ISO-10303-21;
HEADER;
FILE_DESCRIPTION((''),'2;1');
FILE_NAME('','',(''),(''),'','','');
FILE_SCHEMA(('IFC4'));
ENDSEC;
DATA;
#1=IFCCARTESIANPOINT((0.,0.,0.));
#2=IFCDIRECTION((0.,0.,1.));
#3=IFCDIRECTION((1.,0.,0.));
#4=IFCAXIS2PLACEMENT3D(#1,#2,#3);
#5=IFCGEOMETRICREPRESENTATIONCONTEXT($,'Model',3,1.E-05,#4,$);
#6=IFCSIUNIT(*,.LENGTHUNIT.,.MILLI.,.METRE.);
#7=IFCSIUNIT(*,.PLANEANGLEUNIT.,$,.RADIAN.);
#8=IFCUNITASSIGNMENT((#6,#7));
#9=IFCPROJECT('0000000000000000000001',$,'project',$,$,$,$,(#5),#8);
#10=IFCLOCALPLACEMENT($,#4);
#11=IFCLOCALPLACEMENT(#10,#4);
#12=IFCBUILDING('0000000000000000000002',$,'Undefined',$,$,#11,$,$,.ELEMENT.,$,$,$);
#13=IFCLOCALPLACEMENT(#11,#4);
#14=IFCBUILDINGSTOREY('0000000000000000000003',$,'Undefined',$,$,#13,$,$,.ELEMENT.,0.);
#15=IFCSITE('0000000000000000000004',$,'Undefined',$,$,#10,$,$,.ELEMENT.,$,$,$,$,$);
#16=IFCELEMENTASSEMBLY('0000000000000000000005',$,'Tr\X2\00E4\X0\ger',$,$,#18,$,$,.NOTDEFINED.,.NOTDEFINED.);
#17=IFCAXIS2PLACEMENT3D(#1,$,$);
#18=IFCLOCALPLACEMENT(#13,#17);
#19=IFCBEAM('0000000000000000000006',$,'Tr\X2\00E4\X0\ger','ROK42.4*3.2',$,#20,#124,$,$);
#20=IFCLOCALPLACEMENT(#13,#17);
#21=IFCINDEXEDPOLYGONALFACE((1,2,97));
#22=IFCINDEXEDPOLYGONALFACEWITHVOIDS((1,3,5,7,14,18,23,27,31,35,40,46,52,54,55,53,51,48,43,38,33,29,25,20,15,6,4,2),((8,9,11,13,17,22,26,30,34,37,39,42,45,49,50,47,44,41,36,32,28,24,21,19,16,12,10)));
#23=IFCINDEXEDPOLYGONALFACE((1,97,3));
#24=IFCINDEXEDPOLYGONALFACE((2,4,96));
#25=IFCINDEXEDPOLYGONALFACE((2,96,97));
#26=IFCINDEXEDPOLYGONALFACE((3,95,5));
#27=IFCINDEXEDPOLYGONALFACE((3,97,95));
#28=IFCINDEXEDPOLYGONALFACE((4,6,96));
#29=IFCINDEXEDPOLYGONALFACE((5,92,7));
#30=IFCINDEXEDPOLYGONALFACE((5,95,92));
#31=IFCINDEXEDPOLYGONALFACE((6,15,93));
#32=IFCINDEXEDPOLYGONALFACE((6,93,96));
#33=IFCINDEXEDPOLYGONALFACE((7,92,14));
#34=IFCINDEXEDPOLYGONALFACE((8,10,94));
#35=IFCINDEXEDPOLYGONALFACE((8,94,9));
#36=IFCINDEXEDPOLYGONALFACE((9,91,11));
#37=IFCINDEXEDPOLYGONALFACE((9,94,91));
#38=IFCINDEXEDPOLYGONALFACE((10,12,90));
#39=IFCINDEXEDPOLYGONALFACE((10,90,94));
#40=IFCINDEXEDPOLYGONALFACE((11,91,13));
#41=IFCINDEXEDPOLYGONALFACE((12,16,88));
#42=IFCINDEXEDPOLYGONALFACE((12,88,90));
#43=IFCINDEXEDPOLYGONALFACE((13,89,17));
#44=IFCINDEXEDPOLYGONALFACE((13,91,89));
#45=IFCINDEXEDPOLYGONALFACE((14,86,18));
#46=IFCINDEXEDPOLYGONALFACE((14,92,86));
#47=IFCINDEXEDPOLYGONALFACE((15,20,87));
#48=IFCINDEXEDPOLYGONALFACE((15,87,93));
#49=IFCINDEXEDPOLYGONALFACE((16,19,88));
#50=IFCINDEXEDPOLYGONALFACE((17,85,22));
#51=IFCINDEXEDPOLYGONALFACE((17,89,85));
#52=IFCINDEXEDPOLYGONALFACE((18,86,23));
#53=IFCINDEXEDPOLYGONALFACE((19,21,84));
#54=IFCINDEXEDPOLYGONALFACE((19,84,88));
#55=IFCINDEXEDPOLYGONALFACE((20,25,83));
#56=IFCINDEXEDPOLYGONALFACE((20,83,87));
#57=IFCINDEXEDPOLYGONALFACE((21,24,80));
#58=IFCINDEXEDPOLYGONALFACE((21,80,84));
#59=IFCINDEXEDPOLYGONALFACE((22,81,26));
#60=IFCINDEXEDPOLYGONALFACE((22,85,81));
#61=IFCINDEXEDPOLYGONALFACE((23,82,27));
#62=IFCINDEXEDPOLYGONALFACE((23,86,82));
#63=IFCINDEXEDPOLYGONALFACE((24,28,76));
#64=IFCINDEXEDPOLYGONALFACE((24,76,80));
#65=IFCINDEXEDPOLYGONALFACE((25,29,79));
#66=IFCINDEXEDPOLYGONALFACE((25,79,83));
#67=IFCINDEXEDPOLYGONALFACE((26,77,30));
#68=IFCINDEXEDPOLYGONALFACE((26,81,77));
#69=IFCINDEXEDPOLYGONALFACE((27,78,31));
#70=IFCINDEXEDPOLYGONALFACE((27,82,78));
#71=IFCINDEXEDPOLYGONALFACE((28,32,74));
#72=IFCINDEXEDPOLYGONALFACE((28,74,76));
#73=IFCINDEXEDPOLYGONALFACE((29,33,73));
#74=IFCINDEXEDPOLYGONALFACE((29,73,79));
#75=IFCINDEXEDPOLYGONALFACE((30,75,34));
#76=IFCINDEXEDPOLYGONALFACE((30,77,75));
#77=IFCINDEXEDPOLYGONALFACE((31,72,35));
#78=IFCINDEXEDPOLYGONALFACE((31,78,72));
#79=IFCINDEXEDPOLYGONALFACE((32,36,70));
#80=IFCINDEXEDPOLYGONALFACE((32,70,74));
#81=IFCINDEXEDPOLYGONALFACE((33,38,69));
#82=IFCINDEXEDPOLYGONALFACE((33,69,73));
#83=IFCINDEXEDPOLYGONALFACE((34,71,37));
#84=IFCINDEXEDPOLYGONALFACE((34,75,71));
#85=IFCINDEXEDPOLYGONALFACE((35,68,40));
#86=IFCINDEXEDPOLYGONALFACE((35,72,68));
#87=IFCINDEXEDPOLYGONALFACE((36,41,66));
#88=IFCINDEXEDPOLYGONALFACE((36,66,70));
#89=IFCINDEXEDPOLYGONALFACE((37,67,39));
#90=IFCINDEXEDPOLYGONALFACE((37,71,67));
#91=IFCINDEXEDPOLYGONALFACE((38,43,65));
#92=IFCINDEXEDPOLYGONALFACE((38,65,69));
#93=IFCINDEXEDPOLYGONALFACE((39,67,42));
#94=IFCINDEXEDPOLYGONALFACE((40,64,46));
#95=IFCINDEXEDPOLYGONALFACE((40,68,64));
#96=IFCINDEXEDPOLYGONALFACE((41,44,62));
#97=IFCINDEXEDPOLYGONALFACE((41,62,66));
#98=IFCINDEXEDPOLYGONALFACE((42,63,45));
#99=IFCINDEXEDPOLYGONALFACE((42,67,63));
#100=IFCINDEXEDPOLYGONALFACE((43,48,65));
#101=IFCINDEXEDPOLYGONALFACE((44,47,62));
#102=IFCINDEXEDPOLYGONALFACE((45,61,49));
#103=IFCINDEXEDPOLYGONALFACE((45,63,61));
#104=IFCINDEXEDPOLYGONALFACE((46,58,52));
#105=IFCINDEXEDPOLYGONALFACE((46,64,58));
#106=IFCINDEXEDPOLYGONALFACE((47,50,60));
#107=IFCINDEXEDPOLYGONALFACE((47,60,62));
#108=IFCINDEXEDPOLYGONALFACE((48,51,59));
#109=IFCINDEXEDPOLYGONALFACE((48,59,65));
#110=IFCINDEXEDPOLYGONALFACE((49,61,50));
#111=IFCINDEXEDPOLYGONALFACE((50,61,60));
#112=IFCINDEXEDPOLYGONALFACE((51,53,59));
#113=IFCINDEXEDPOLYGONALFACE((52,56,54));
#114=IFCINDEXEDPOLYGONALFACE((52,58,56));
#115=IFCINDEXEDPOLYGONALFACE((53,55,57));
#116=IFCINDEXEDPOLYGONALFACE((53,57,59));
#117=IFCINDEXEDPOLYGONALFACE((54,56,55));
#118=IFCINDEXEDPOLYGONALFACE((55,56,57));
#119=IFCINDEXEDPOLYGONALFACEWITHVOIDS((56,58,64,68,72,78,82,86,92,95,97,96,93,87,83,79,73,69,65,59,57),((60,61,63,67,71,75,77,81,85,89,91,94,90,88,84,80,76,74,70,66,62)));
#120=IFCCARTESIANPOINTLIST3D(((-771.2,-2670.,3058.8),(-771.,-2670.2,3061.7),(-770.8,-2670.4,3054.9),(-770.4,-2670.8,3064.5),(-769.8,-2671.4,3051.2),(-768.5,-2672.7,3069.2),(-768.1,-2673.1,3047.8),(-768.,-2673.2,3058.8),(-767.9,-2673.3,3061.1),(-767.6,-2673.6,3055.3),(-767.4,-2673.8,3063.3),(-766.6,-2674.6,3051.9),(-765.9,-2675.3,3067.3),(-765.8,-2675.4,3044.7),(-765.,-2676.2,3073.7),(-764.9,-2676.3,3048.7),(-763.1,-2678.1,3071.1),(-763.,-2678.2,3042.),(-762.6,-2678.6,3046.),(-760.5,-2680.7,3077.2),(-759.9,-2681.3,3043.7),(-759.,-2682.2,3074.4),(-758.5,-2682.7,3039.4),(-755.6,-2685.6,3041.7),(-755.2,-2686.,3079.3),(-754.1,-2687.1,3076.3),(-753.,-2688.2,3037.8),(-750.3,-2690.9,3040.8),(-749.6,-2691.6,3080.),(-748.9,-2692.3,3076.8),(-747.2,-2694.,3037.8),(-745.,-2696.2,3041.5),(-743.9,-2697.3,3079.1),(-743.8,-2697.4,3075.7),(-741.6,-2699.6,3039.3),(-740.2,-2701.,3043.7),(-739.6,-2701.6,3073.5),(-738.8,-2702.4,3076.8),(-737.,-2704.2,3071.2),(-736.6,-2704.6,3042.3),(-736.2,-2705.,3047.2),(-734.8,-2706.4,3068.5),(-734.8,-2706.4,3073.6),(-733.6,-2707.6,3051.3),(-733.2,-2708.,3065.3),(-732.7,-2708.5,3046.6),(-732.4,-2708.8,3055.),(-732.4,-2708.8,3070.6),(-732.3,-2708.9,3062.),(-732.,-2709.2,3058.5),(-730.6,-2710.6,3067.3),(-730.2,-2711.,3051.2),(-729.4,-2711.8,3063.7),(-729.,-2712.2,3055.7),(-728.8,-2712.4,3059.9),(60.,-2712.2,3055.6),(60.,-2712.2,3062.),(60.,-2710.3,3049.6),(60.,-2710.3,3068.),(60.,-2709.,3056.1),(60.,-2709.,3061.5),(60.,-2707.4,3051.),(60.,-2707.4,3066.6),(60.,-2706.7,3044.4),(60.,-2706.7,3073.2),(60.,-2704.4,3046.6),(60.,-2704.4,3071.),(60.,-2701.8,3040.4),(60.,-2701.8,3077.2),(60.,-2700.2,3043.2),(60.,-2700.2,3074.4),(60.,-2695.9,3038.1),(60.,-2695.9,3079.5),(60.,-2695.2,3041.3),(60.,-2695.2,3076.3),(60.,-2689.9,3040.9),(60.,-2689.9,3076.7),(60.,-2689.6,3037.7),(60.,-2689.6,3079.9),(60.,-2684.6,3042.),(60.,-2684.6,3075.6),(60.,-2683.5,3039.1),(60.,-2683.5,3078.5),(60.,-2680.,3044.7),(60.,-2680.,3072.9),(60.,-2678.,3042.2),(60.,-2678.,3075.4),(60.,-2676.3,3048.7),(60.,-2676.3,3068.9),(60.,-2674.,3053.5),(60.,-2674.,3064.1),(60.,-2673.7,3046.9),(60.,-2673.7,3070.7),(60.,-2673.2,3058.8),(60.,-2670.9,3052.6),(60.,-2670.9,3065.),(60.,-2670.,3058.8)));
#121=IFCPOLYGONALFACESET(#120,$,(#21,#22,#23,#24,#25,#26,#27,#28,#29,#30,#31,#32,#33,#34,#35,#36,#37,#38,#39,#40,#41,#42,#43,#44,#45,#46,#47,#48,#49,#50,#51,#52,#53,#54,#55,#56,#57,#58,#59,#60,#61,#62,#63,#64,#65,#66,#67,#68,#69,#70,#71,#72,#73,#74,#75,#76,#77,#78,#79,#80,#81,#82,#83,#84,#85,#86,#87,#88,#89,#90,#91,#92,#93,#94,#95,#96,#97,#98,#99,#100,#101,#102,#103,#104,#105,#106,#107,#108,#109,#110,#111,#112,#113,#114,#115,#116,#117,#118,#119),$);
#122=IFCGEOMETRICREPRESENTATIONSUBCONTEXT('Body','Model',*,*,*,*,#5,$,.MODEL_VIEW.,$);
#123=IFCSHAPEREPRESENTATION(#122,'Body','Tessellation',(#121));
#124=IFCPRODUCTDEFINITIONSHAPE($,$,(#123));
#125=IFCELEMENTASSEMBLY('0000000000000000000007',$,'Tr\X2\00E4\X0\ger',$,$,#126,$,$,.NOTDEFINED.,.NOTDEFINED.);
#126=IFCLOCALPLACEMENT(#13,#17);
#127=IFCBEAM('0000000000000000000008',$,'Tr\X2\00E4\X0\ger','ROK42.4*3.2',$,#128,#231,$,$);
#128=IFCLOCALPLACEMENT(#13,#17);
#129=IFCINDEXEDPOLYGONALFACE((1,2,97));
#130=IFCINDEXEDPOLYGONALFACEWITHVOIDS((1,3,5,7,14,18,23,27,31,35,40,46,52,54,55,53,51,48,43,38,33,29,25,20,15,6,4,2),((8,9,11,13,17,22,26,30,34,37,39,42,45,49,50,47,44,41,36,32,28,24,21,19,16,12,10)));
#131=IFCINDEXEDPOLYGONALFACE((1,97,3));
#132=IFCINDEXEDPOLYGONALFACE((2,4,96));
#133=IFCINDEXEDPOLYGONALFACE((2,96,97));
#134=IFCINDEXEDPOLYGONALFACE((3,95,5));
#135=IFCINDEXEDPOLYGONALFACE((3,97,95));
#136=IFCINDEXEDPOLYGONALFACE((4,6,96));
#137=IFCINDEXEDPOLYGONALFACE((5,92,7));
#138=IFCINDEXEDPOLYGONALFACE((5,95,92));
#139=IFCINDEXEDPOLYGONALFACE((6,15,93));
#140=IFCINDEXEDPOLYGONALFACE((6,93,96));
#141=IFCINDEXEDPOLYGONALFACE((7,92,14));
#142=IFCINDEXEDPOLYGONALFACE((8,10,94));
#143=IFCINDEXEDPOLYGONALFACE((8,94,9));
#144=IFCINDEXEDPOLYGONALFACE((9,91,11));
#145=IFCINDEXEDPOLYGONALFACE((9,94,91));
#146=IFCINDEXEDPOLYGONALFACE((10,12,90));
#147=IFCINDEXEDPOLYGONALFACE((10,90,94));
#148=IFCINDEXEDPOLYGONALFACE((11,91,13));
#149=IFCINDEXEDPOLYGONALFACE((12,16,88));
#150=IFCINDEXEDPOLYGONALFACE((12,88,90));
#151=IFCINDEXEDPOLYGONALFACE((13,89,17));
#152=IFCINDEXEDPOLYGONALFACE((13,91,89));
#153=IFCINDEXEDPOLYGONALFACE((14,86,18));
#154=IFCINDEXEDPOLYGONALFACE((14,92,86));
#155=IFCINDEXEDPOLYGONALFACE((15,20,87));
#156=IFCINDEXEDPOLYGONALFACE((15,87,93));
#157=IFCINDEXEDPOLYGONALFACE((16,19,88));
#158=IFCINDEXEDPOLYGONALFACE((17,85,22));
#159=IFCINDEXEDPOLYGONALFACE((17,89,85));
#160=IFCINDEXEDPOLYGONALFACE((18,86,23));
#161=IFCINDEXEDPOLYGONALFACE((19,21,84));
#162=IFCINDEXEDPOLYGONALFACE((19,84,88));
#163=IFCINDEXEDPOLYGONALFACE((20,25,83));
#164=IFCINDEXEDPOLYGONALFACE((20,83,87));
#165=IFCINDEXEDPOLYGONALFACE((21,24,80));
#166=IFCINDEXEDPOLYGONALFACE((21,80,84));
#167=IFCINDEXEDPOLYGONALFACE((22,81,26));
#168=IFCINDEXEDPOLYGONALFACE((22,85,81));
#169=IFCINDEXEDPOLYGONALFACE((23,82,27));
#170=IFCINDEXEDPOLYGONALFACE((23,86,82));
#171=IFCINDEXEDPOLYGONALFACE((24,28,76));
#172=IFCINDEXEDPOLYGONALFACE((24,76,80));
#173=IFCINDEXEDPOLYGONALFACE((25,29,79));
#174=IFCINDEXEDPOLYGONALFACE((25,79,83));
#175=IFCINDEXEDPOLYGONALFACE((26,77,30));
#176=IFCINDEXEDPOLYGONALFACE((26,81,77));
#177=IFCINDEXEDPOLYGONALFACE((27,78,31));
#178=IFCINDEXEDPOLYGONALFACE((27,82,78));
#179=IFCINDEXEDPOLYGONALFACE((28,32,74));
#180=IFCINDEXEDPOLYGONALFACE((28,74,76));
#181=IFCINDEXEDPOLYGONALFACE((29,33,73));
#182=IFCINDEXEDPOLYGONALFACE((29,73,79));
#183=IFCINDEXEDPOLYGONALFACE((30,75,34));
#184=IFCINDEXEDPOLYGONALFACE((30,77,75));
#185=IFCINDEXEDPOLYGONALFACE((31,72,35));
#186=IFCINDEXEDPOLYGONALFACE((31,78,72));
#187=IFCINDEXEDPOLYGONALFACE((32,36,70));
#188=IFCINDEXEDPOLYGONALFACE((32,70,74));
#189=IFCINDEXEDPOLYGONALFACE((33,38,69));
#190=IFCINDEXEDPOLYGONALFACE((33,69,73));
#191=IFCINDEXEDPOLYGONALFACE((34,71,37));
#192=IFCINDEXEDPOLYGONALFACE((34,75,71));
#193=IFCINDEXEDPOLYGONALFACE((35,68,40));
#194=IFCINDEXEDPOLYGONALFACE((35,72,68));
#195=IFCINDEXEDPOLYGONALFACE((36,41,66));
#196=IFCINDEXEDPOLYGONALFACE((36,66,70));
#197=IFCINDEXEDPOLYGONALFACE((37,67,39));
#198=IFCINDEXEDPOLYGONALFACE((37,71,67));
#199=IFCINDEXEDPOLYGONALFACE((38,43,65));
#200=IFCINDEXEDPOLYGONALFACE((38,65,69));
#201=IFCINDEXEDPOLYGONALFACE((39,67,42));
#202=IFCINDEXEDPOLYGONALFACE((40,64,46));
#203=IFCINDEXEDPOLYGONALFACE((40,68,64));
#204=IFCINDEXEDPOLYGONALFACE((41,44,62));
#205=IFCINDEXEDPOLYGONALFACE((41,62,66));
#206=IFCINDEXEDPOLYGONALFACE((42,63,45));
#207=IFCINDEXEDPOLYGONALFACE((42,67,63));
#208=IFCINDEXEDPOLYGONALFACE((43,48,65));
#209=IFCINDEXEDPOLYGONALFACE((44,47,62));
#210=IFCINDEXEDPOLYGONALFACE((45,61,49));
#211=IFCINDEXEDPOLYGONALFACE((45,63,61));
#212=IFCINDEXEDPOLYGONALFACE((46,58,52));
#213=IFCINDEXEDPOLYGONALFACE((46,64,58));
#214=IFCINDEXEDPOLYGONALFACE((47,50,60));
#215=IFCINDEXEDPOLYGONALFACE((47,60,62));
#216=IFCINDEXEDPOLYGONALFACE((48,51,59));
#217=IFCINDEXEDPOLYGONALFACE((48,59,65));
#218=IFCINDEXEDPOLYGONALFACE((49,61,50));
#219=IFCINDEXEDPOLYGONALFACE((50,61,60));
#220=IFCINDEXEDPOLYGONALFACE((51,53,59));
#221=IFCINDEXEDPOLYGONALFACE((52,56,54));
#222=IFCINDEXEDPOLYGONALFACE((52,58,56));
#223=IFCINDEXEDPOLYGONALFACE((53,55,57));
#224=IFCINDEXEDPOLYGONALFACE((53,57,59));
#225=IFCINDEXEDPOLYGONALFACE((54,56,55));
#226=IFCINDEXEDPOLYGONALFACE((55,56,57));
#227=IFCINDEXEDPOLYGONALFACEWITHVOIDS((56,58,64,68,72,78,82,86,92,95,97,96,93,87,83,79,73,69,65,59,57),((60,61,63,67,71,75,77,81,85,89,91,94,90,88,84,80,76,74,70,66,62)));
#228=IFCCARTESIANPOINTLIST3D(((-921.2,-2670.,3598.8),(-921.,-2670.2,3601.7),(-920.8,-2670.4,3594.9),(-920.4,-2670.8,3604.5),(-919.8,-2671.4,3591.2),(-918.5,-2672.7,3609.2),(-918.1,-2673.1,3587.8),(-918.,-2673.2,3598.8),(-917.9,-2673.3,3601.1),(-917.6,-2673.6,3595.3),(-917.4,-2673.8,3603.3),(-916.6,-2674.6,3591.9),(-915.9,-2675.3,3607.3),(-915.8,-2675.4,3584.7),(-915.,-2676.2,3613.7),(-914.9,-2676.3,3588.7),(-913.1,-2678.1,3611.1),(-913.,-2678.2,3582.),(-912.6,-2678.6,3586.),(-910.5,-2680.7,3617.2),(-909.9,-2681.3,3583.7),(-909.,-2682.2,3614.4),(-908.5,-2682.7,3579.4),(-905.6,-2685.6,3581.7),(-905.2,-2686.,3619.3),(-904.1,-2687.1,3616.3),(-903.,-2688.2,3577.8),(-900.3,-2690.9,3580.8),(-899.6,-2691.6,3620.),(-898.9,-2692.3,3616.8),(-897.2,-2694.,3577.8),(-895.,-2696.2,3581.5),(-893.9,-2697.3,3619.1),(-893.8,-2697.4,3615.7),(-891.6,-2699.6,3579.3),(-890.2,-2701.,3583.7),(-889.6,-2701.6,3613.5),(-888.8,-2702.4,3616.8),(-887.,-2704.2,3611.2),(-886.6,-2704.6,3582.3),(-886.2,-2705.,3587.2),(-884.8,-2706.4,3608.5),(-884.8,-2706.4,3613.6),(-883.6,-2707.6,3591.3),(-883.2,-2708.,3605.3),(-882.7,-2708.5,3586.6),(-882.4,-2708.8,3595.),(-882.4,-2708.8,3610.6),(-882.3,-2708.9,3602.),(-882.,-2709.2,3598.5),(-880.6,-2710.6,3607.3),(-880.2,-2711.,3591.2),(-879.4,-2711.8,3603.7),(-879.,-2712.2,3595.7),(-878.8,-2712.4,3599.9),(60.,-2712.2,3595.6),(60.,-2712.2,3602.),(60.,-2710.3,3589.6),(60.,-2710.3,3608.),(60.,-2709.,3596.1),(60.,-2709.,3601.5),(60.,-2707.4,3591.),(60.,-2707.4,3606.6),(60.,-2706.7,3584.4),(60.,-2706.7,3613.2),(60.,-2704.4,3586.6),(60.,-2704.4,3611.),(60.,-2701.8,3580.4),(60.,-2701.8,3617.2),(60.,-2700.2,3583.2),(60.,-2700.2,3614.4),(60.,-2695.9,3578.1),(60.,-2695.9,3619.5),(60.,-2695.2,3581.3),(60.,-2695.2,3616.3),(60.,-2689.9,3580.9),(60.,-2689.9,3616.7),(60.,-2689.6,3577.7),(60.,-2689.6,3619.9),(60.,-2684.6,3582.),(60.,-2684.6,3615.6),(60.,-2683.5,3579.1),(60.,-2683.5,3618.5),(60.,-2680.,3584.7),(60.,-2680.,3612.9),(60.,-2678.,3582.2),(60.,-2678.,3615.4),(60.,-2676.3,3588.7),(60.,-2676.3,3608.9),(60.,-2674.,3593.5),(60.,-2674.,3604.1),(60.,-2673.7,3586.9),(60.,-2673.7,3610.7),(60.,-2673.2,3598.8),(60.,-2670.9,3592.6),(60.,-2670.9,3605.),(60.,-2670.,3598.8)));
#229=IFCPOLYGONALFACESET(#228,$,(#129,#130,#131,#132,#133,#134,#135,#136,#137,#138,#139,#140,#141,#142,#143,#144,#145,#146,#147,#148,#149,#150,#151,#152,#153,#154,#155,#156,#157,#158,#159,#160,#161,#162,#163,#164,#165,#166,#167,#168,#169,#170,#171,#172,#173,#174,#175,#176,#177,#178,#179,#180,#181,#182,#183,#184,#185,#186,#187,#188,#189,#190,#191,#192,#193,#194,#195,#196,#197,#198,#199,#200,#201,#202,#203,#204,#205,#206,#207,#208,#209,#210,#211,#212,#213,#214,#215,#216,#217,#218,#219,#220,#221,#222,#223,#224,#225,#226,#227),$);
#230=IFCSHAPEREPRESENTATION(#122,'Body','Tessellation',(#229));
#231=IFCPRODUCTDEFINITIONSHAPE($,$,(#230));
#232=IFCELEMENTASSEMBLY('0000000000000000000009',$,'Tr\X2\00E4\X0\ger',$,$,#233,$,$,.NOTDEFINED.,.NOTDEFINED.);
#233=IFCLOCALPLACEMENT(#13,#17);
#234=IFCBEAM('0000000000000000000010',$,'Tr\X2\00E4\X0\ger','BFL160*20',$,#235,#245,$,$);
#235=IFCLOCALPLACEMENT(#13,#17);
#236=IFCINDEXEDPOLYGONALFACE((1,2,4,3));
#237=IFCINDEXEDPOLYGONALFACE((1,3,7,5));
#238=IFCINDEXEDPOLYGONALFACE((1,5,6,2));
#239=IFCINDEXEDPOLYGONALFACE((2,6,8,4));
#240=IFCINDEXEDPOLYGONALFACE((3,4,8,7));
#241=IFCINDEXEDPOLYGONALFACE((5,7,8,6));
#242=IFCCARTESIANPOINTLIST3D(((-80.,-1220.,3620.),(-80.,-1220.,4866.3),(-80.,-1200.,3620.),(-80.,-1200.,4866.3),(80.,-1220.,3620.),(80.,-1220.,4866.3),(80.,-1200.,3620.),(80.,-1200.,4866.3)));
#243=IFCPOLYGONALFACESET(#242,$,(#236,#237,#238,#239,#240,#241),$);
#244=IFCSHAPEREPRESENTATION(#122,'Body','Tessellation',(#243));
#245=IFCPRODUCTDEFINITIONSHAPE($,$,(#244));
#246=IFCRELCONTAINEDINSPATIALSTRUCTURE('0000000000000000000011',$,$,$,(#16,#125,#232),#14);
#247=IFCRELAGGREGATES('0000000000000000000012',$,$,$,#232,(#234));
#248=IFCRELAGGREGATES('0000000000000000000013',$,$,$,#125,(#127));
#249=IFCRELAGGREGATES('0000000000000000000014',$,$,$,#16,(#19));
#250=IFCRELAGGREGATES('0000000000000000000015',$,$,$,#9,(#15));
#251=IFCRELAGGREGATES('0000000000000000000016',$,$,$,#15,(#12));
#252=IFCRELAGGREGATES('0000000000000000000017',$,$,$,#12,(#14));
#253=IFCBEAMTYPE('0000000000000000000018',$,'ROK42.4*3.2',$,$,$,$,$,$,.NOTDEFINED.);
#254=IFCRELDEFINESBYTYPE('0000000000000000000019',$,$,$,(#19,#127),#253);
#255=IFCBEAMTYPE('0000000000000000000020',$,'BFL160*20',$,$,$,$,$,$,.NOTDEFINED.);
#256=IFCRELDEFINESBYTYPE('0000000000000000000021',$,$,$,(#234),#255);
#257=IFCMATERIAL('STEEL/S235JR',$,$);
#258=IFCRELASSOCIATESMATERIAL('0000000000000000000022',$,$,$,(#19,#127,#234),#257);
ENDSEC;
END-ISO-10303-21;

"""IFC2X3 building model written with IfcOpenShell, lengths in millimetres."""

from ifc_helpers import new_model, si_unit, frame, origin_with_axes, origin_2d_with_axis, place, context, subcontext, project, spatial, rectangle, hollow_circle, extrude, clip, halfspace, material, type_object, element, aggregate, save


model = new_model("IFC2X3")

# Units and contexts
model_context = context("Model", 3, precision=1e-05, world=origin_with_axes())
body_context = subcontext(model_context, "Body", "Model", "MODEL_VIEW")
ifc_project = project(units=[si_unit("LENGTHUNIT", "METRE", prefix="MILLI"), si_unit("PLANEANGLEUNIT", "RADIAN")], contexts=[model_context])

# Site, building, storey
site_placement = place(None, origin_with_axes())
site = spatial("IfcSite", under=ifc_project, at=site_placement, Name="Undefined", CompositionType="ELEMENT")
building_placement = place(site_placement, origin_with_axes())
building = spatial("IfcBuilding", under=site, at=building_placement, Name="Undefined", CompositionType="ELEMENT")
storey_placement = place(building_placement, origin_with_axes())
storey = spatial("IfcBuildingStorey", under=building, at=storey_placement, Name="Undefined", CompositionType="ELEMENT", Elevation=0.0)

# Element assemblies, beams
assembly_1_placement = place(storey_placement, origin_with_axes())
assembly_1 = element("IfcElementAssembly", 1, at=assembly_1_placement, inside=storey, Name="Träger", AssemblyPlace="NOTDEFINED", PredefinedType="NOTDEFINED")
ifc_material_1 = material(Name="STEEL/S235JR")
beam_type_1 = type_object("IfcBeamType", Name="ROK42.4*3.2", PredefinedType="NOTDEFINED")
beam_1_placement = place(assembly_1_placement, frame((60.0, -2691.2, 3058.8), z_axis=(0.0, 0.0, 1.0), x_axis=(-1.0, 0.0, 0.0)))
beam_1 = element("IfcBeam", 2, at=beam_1_placement, type_object=beam_type_1, material=ifc_material_1, Name="Träger", Description="ROK42.4*3.2", context=body_context, shape_type="Clipping", body=[
    clip(extrude(hollow_circle(Radius=21.2, WallThickness=3.2, at=origin_2d_with_axis()), frame((831.4, 0.0, 0.0), z_axis=(-1.0, 0.0, 0.0), x_axis=(0.0, -1.0, 0.0)), (0.0, 0.0, 1.0), 831.4), halfspace(frame((831.2, -21.2, 0.0), z_axis=(0.707107, 0.707107, 0.0), x_axis=(0.0, 0.0, 1.0)), False)),
])
assembly_2_placement = place(storey_placement, origin_with_axes())
assembly_2 = element("IfcElementAssembly", 3, at=assembly_2_placement, inside=storey, Name="Träger", AssemblyPlace="NOTDEFINED", PredefinedType="NOTDEFINED")
beam_2_placement = place(assembly_2_placement, frame((60.0, -2691.2, 3598.8), z_axis=(0.0, 0.0, 1.0), x_axis=(-1.0, 0.0, 0.0)))
beam_2 = element("IfcBeam", 4, at=beam_2_placement, type_object=beam_type_1, material=ifc_material_1, Name="Träger", Description="ROK42.4*3.2", context=body_context, shape_type="Clipping", body=[
    clip(extrude(hollow_circle(Radius=21.2, WallThickness=3.2, at=origin_2d_with_axis()), frame((981.4, 0.0, 0.0), z_axis=(-1.0, 0.0, 0.0), x_axis=(0.0, -1.0, 0.0)), (0.0, 0.0, 1.0), 981.4), halfspace(frame((981.2, -21.2, 0.0), z_axis=(0.707107, 0.707107, 0.0), x_axis=(0.0, 0.0, 1.0)), False)),
])

# Element assembly, beam
assembly_3_placement = place(storey_placement, origin_with_axes())
assembly_3 = element("IfcElementAssembly", 5, at=assembly_3_placement, inside=storey, Name="Träger", AssemblyPlace="NOTDEFINED", PredefinedType="NOTDEFINED")
beam_type_2 = type_object("IfcBeamType", Name="BFL160*20", PredefinedType="NOTDEFINED")
beam_3_placement = place(assembly_3_placement, frame((0.0, -1210.0, 3620.0), z_axis=(-1.0, 0.0, 0.0), x_axis=(0.0, 0.0, 1.0)))
beam_3 = element("IfcBeam", 6, at=beam_3_placement, type_object=beam_type_2, material=ifc_material_1, Name="Träger", Description="BFL160*20", context=body_context, shape_type="SweptSolid", body=[
    extrude(rectangle(XDim=20.0, YDim=160.0, at=origin_2d_with_axis()), frame((1246.3, 0.0, 0.0), z_axis=(-1.0, 0.0, 0.0), x_axis=(0.0, -1.0, 0.0)), (0.0, 0.0, 1.0), 1246.3),
])
aggregate(assembly_3, [beam_3])

aggregate(assembly_2, [beam_2])
aggregate(assembly_1, [beam_1])

save(model, "model.ifc")
